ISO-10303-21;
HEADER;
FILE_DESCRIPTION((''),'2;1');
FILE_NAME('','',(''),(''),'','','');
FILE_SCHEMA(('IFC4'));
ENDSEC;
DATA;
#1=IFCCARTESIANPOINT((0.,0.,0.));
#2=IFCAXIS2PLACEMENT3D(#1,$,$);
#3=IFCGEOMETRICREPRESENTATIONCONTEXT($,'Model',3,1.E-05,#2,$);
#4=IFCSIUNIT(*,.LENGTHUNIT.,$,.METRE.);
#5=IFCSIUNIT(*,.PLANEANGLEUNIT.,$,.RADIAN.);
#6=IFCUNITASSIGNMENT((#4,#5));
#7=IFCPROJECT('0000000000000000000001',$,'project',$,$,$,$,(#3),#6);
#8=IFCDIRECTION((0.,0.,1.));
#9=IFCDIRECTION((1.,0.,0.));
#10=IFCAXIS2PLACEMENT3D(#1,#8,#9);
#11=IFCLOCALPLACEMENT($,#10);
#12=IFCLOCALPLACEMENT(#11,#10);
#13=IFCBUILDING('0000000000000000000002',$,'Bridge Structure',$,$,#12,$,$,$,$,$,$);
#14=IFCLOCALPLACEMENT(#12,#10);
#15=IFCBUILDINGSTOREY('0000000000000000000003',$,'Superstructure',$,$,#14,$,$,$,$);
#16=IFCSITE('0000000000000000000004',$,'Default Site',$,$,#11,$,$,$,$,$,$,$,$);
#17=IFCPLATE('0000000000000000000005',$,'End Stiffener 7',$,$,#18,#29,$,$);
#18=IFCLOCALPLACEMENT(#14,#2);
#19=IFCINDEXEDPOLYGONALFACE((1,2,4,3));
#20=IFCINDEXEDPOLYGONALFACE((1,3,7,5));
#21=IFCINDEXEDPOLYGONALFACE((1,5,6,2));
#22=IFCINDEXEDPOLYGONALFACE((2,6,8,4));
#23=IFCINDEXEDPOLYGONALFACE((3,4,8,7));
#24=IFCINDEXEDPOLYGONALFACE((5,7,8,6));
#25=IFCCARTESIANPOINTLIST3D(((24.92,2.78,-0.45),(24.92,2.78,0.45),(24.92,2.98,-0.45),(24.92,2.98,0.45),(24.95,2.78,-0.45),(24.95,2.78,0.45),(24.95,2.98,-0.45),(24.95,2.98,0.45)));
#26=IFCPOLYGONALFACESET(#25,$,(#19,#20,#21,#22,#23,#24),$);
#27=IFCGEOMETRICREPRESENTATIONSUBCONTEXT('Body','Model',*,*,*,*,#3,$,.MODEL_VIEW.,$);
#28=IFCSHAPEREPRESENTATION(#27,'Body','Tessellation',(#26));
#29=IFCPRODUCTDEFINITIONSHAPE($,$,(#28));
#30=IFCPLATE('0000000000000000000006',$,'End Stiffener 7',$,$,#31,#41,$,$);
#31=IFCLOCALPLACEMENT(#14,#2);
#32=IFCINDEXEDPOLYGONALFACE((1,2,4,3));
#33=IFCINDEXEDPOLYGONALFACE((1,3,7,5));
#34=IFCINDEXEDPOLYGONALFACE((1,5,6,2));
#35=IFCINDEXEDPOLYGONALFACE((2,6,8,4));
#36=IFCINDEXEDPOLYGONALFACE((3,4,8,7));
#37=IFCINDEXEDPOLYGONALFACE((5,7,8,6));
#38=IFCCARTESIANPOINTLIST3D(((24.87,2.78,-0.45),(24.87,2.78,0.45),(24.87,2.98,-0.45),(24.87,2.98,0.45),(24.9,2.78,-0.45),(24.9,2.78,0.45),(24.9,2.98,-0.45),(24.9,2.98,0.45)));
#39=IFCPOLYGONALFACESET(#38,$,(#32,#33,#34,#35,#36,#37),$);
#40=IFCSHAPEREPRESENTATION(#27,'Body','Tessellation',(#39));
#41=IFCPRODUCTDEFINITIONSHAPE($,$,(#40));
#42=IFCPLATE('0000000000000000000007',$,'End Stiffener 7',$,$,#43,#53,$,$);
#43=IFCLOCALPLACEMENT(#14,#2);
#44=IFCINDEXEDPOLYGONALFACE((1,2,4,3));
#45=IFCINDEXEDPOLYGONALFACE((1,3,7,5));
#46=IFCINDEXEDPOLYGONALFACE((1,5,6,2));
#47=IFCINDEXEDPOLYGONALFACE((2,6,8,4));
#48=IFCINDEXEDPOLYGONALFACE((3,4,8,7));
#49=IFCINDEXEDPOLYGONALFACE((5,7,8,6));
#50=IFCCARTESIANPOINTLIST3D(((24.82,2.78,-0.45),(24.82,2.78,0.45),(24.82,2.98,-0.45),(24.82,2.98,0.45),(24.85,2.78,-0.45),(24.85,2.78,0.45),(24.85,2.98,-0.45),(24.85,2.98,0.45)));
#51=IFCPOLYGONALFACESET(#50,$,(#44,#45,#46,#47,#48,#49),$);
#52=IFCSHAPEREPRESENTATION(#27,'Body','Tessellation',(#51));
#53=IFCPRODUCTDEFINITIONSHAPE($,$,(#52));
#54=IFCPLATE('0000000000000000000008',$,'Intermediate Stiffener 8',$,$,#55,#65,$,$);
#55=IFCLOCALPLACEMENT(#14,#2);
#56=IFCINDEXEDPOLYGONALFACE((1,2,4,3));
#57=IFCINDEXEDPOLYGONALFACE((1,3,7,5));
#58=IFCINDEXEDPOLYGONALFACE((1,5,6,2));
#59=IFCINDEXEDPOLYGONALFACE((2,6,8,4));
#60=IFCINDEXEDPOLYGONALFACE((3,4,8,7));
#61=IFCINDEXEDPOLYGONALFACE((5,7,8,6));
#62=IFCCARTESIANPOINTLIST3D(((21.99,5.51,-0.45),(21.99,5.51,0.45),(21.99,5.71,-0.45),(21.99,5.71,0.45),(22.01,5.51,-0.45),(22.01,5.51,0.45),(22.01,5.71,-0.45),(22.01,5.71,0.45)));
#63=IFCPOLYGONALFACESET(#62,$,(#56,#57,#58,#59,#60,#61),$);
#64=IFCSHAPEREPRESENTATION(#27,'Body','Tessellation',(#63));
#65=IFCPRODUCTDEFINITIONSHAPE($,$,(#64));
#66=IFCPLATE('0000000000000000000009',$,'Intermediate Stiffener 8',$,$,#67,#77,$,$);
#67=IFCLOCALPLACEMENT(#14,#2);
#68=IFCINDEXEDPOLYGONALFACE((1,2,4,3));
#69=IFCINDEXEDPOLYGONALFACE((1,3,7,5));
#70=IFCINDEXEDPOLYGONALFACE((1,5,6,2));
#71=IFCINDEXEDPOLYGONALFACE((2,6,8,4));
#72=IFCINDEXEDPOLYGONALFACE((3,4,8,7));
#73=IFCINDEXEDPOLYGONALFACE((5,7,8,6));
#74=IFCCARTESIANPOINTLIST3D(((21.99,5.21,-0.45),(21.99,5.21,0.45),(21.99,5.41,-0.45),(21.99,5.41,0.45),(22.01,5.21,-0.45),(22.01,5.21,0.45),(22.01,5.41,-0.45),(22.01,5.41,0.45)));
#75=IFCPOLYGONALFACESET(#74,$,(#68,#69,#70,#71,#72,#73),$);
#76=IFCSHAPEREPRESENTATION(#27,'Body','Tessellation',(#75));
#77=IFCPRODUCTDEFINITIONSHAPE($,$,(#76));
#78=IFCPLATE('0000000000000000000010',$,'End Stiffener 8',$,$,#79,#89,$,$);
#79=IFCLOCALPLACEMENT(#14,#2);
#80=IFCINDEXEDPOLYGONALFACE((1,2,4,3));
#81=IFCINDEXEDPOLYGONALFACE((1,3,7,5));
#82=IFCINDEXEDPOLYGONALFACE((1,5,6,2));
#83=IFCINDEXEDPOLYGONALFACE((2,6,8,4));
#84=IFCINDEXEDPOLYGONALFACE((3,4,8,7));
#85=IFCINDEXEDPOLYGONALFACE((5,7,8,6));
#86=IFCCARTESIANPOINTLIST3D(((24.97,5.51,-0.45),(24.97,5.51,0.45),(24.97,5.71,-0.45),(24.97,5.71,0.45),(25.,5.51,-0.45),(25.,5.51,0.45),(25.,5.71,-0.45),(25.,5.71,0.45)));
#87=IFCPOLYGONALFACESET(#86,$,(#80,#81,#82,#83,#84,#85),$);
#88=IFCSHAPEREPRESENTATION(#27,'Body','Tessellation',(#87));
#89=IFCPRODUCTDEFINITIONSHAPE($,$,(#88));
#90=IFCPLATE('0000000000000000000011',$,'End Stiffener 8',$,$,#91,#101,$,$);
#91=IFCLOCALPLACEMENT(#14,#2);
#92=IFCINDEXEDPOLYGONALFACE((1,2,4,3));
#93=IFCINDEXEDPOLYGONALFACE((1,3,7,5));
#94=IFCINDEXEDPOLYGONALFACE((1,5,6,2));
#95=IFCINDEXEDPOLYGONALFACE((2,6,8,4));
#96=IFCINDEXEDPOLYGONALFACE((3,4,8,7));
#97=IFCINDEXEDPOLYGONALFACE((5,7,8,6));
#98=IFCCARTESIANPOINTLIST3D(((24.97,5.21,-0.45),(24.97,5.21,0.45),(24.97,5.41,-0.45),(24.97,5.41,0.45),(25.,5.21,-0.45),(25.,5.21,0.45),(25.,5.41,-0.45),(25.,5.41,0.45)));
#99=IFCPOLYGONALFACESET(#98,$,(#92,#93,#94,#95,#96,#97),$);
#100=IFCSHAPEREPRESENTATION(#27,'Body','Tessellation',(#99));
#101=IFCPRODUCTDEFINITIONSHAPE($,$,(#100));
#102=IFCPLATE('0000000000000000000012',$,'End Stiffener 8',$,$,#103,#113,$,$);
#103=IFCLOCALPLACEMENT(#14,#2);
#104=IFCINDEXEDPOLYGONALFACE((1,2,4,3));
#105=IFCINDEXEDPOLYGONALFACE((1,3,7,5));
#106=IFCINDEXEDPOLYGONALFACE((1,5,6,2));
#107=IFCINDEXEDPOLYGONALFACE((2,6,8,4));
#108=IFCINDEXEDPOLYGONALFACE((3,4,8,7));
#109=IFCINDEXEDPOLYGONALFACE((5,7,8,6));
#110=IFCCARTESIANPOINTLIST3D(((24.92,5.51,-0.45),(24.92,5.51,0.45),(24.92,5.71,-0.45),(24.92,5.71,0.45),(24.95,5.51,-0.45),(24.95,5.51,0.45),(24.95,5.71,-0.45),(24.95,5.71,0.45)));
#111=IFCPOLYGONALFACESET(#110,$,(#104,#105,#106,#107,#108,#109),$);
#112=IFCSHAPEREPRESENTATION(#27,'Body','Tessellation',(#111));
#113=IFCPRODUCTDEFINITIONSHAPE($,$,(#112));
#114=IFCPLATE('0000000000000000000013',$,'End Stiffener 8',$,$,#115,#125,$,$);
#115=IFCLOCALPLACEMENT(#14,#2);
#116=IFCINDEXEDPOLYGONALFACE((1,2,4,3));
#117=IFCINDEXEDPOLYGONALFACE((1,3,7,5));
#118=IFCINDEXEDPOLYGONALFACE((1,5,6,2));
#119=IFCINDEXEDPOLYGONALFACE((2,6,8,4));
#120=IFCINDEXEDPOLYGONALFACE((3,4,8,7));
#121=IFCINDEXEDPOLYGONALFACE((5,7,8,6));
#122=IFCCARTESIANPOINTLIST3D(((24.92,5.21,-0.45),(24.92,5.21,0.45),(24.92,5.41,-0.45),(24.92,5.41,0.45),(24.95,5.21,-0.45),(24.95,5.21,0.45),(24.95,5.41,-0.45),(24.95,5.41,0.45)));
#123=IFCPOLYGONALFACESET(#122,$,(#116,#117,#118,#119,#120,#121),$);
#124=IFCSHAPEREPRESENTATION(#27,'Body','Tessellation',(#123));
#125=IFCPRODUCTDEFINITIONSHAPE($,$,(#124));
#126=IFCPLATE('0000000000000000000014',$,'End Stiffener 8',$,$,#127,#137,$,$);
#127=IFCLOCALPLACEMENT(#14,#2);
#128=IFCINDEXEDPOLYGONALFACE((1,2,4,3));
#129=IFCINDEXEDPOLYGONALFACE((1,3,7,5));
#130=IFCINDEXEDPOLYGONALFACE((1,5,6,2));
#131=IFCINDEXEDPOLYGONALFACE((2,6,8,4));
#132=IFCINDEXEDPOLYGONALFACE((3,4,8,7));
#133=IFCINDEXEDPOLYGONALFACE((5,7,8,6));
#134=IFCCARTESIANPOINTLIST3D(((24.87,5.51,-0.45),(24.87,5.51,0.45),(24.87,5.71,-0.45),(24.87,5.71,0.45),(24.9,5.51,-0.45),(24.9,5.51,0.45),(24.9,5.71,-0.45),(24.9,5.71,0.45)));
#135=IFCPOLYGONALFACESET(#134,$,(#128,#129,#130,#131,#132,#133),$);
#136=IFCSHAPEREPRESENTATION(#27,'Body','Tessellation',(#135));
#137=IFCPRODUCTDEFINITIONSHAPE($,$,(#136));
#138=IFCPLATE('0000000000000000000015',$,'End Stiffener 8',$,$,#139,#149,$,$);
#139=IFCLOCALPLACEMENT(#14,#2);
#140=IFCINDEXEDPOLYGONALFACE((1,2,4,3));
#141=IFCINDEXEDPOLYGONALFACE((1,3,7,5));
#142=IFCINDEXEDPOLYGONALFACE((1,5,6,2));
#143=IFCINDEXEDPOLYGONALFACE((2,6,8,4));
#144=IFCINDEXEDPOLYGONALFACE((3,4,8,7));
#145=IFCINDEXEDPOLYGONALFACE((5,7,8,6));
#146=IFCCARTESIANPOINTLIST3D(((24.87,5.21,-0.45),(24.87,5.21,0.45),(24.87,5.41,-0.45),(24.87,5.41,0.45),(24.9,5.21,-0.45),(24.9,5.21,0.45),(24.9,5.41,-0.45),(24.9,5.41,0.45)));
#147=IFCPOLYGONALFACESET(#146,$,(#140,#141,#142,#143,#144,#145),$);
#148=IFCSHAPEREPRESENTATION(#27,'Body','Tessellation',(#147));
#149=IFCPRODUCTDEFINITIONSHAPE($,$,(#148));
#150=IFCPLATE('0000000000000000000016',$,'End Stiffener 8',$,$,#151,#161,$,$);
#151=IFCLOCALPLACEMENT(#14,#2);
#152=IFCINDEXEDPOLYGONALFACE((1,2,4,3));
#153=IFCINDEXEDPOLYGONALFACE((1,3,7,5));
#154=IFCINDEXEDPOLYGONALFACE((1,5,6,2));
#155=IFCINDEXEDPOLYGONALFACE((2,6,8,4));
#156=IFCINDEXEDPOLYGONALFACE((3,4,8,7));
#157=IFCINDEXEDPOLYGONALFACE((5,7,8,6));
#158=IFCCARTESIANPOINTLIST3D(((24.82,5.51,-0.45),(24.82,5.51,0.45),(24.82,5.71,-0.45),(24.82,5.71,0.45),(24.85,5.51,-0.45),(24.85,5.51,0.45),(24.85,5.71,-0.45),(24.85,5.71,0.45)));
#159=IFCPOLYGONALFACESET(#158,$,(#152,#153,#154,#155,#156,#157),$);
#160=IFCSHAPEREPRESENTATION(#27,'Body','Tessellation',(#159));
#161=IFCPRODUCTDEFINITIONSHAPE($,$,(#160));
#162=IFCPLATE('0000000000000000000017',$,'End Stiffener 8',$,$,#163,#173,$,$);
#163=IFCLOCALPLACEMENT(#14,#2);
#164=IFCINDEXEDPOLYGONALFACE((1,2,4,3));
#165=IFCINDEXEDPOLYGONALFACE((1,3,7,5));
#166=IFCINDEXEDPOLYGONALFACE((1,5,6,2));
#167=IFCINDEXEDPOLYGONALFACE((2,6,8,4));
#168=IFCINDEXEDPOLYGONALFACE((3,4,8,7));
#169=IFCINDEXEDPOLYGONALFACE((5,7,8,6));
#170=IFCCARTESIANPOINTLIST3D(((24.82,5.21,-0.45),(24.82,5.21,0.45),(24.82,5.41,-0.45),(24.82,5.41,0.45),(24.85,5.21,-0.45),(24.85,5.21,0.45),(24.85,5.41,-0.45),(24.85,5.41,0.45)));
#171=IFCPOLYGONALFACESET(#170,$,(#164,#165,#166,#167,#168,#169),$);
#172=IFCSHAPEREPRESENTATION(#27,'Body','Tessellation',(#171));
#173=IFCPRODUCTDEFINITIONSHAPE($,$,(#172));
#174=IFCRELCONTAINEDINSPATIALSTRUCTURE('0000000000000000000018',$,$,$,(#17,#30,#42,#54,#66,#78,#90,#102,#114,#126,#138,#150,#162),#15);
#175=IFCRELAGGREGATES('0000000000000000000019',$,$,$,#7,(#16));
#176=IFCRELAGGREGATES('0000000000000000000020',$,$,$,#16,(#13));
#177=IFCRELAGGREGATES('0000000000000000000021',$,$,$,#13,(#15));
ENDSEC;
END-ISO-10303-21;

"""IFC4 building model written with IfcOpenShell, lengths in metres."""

from ifc_helpers import new_model, si_unit, frame, origin, origin_with_axes, origin_2d_with_axis, place, context, subcontext, project, spatial, rectangle, extrude, element, save


model = new_model("IFC4")

# Units and contexts
model_context = context("Model", 3, precision=1e-05, world=origin())
body_context = subcontext(model_context, "Body", "Model", "MODEL_VIEW")
ifc_project = project(units=[si_unit("LENGTHUNIT", "METRE"), si_unit("PLANEANGLEUNIT", "RADIAN")], contexts=[model_context])

# Site, building, storey
site_placement = place(None, origin_with_axes())
site = spatial("IfcSite", under=ifc_project, at=site_placement, Name="Default Site")
building_placement = place(site_placement, origin_with_axes())
building = spatial("IfcBuilding", under=site, at=building_placement, Name="Bridge Structure")
storey_placement = place(building_placement, origin_with_axes())
storey = spatial("IfcBuildingStorey", under=building, at=storey_placement, Name="Superstructure")

# Plates
for number, where, z_axis, x_axis, name in (
    (1, (24.935, 2.88, -0.45), (0.0, 0.0, 1.0), (1.0, 0.0, 0.0), "End Stiffener 7"),
    (2, (24.885, 2.88, -0.45), (0.0, 0.0, 1.0), (1.0, 0.0, 0.0), "End Stiffener 7"),
    (3, (24.835, 2.88, -0.45), (0.0, 0.0, 1.0), (1.0, 0.0, 0.0), "End Stiffener 7"),
):
    element("IfcPlate", number, at=place(storey_placement, frame(where, z_axis=z_axis, x_axis=x_axis)), inside=storey, Name=name, context=body_context, shape_type="SweptSolid", body=[
        extrude(rectangle(XDim=0.03, YDim=0.2, at=origin_2d_with_axis()), origin_with_axes(), (0.0, 0.0, 1.0), 0.9),
    ])
for number, where, z_axis, x_axis, name in (
    (4, (22.0, 5.61, -0.45), (0.0, 0.0, 1.0), (1.0, 0.0, 0.0), "Intermediate Stiffener 8"),
    (5, (22.0, 5.31, -0.45), (0.0, 0.0, 1.0), (1.0, 0.0, 0.0), "Intermediate Stiffener 8"),
):
    element("IfcPlate", number, at=place(storey_placement, frame(where, z_axis=z_axis, x_axis=x_axis)), inside=storey, Name=name, context=body_context, shape_type="SweptSolid", body=[
        extrude(rectangle(XDim=0.02, YDim=0.2, at=origin_2d_with_axis()), origin_with_axes(), (0.0, 0.0, 1.0), 0.9),
    ])
for number, where, z_axis, x_axis, name in (
    (6, (24.985, 5.61, -0.45), (0.0, 0.0, 1.0), (1.0, 0.0, 0.0), "End Stiffener 8"),
    (7, (24.985, 5.31, -0.45), (0.0, 0.0, 1.0), (1.0, 0.0, 0.0), "End Stiffener 8"),
    (8, (24.935, 5.61, -0.45), (0.0, 0.0, 1.0), (1.0, 0.0, 0.0), "End Stiffener 8"),
    (9, (24.935, 5.31, -0.45), (0.0, 0.0, 1.0), (1.0, 0.0, 0.0), "End Stiffener 8"),
    (10, (24.885, 5.61, -0.45), (0.0, 0.0, 1.0), (1.0, 0.0, 0.0), "End Stiffener 8"),
    (11, (24.885, 5.31, -0.45), (0.0, 0.0, 1.0), (1.0, 0.0, 0.0), "End Stiffener 8"),
    (12, (24.835, 5.61, -0.45), (0.0, 0.0, 1.0), (1.0, 0.0, 0.0), "End Stiffener 8"),
    (13, (24.835, 5.31, -0.45), (0.0, 0.0, 1.0), (1.0, 0.0, 0.0), "End Stiffener 8"),
):
    element("IfcPlate", number, at=place(storey_placement, frame(where, z_axis=z_axis, x_axis=x_axis)), inside=storey, Name=name, context=body_context, shape_type="SweptSolid", body=[
        extrude(rectangle(XDim=0.03, YDim=0.2, at=origin_2d_with_axis()), origin_with_axes(), (0.0, 0.0, 1.0), 0.9),
    ])

save(model, "model.ifc")
